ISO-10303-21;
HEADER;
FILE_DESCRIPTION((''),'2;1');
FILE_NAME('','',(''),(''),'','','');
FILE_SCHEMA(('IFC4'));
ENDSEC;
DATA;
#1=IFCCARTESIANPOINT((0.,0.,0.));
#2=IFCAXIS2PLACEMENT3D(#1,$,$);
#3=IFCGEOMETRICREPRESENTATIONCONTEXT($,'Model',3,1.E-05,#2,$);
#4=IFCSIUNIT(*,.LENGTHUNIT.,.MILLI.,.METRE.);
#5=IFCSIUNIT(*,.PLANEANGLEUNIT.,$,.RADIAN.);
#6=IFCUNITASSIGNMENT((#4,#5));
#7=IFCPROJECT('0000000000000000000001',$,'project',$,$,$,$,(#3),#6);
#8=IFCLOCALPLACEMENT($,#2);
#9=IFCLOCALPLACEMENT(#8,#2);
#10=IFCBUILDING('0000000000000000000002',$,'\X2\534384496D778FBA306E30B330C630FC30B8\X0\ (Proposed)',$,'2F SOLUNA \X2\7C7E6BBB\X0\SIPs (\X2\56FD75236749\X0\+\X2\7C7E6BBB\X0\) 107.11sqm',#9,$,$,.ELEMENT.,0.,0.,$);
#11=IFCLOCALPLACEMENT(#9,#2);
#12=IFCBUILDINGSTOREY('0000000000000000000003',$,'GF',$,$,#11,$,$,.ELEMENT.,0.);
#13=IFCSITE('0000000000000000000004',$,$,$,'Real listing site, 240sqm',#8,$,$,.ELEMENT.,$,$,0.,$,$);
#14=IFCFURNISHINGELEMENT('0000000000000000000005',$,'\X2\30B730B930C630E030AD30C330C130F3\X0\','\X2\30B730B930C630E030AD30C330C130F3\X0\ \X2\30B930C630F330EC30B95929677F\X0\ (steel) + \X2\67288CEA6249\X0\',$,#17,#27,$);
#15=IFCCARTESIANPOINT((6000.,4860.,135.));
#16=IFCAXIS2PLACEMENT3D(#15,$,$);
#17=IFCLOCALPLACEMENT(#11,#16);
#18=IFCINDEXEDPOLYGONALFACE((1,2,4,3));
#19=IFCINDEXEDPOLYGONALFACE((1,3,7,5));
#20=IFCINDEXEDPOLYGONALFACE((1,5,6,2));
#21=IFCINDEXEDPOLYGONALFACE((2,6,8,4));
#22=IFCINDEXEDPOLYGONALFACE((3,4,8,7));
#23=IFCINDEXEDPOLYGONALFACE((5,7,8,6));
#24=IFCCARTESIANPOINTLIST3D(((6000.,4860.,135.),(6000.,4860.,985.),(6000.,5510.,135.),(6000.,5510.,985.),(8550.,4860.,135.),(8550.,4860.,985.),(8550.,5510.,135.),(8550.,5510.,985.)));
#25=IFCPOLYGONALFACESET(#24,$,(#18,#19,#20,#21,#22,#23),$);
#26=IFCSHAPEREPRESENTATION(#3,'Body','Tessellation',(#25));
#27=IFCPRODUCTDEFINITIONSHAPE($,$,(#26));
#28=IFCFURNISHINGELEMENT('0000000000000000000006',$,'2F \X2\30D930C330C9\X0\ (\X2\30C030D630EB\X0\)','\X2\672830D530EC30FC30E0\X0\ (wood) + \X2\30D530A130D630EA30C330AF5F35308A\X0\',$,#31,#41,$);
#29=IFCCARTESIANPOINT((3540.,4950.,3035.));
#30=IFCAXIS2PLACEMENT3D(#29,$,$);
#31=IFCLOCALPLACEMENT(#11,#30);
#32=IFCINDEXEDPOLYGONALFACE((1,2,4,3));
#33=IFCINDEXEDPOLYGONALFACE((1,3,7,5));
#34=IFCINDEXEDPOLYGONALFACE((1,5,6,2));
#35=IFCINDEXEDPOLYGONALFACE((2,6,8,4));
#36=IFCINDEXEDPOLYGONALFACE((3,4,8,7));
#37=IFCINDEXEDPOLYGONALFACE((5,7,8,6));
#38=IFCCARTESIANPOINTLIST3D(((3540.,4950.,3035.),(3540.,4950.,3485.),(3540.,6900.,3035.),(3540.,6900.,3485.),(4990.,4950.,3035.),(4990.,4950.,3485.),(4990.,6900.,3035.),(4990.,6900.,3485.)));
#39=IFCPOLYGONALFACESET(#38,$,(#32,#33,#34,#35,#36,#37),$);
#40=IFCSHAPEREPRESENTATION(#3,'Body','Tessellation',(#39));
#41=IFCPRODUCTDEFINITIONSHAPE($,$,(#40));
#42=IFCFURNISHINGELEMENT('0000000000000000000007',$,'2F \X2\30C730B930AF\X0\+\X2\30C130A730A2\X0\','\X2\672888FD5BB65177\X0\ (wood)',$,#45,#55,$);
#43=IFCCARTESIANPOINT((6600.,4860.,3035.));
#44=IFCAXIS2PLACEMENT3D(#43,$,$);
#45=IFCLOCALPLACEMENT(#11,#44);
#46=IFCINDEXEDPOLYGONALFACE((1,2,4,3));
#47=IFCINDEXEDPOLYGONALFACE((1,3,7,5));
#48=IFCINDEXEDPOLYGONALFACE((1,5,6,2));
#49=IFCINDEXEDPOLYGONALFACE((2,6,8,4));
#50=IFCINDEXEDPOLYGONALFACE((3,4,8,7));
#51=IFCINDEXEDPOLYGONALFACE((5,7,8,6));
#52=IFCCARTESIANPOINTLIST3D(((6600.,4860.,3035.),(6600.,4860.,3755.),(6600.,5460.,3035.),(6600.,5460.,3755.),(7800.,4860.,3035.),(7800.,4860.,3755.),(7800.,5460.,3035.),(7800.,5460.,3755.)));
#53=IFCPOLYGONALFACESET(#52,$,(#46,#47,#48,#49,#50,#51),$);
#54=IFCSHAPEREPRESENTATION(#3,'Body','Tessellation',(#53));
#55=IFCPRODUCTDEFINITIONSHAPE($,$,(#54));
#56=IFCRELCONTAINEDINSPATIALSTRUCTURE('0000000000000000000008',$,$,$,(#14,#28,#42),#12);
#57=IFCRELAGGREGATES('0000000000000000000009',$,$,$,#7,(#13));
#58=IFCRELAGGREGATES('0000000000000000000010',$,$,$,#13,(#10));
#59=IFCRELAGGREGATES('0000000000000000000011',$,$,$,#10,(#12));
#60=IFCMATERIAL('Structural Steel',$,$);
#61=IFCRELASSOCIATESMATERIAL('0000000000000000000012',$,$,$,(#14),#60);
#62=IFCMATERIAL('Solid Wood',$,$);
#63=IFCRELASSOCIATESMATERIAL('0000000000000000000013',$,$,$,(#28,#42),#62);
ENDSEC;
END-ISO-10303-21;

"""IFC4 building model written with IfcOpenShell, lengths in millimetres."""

from ifc_helpers import new_model, si_unit, frame, frame_2d, origin, place, context, project, spatial, rectangle, extrude, material, element, save


model = new_model("IFC4")

# Units and contexts
model_context = context("Model", 3, precision=1e-05, world=origin())
ifc_project = project(units=[si_unit("LENGTHUNIT", "METRE", prefix="MILLI"), si_unit("PLANEANGLEUNIT", "RADIAN")], contexts=[model_context])

# Site, building, storey
site_placement = place(None, origin())
site = spatial("IfcSite", under=ifc_project, at=site_placement, ObjectType="Real listing site, 240sqm", CompositionType="ELEMENT", RefElevation=0.0)
building_placement = place(site_placement, origin())
building = spatial("IfcBuilding", under=site, at=building_placement, Name="千葉海辺のコテージ (Proposed)", ObjectType="2F SOLUNA 籾殻SIPs (国産杉+籾殻) 107.11sqm", CompositionType="ELEMENT", ElevationOfRefHeight=0.0, ElevationOfTerrain=0.0)
storey_placement = place(building_placement, origin())
storey = spatial("IfcBuildingStorey", under=building, at=storey_placement, Name="GF", CompositionType="ELEMENT", Elevation=0.0)

# Shared definitions
ifc_material_1 = material(Name="Solid Wood")

# Furnishing elements
ifc_material_2 = material(Name="Structural Steel")
furnishing_1_placement = place(storey_placement, frame((6000.0, 4860.0, 135.0)))
element("IfcFurnishingElement", 1, at=furnishing_1_placement, inside=storey, material=ifc_material_2, Name="システムキッチン", Description="システムキッチン ステンレス天板 (steel) + 木質扉", context=model_context, shape_type="SweptSolid", body=[
    extrude(rectangle(XDim=2550.0, YDim=650.0, at=frame_2d((1275.0, 325.0))), frame((6000.0, 4860.0, 135.0)), (0.0, 0.0, 1.0), 850.0),
])
furnishing_2_placement = place(storey_placement, frame((3540.0, 4950.0, 3035.0)))
element("IfcFurnishingElement", 2, at=furnishing_2_placement, inside=storey, material=ifc_material_1, Name="2F ベッド (ダブル)", Description="木フレーム (wood) + ファブリック張り", context=model_context, shape_type="SweptSolid", body=[
    extrude(rectangle(XDim=1450.0, YDim=1950.0, at=frame_2d((725.0, 975.0))), frame((3540.0, 4950.0, 3035.0)), (0.0, 0.0, 1.0), 450.0),
])
furnishing_3_placement = place(storey_placement, frame((6600.0, 4860.0, 3035.0)))
element("IfcFurnishingElement", 3, at=furnishing_3_placement, inside=storey, material=ifc_material_1, Name="2F デスク+チェア", Description="木製家具 (wood)", context=model_context, shape_type="SweptSolid", body=[
    extrude(rectangle(XDim=1200.0, YDim=600.0, at=frame_2d((600.0, 300.0))), frame((6600.0, 4860.0, 3035.0)), (0.0, 0.0, 1.0), 720.0),
])

save(model, "model.ifc")
